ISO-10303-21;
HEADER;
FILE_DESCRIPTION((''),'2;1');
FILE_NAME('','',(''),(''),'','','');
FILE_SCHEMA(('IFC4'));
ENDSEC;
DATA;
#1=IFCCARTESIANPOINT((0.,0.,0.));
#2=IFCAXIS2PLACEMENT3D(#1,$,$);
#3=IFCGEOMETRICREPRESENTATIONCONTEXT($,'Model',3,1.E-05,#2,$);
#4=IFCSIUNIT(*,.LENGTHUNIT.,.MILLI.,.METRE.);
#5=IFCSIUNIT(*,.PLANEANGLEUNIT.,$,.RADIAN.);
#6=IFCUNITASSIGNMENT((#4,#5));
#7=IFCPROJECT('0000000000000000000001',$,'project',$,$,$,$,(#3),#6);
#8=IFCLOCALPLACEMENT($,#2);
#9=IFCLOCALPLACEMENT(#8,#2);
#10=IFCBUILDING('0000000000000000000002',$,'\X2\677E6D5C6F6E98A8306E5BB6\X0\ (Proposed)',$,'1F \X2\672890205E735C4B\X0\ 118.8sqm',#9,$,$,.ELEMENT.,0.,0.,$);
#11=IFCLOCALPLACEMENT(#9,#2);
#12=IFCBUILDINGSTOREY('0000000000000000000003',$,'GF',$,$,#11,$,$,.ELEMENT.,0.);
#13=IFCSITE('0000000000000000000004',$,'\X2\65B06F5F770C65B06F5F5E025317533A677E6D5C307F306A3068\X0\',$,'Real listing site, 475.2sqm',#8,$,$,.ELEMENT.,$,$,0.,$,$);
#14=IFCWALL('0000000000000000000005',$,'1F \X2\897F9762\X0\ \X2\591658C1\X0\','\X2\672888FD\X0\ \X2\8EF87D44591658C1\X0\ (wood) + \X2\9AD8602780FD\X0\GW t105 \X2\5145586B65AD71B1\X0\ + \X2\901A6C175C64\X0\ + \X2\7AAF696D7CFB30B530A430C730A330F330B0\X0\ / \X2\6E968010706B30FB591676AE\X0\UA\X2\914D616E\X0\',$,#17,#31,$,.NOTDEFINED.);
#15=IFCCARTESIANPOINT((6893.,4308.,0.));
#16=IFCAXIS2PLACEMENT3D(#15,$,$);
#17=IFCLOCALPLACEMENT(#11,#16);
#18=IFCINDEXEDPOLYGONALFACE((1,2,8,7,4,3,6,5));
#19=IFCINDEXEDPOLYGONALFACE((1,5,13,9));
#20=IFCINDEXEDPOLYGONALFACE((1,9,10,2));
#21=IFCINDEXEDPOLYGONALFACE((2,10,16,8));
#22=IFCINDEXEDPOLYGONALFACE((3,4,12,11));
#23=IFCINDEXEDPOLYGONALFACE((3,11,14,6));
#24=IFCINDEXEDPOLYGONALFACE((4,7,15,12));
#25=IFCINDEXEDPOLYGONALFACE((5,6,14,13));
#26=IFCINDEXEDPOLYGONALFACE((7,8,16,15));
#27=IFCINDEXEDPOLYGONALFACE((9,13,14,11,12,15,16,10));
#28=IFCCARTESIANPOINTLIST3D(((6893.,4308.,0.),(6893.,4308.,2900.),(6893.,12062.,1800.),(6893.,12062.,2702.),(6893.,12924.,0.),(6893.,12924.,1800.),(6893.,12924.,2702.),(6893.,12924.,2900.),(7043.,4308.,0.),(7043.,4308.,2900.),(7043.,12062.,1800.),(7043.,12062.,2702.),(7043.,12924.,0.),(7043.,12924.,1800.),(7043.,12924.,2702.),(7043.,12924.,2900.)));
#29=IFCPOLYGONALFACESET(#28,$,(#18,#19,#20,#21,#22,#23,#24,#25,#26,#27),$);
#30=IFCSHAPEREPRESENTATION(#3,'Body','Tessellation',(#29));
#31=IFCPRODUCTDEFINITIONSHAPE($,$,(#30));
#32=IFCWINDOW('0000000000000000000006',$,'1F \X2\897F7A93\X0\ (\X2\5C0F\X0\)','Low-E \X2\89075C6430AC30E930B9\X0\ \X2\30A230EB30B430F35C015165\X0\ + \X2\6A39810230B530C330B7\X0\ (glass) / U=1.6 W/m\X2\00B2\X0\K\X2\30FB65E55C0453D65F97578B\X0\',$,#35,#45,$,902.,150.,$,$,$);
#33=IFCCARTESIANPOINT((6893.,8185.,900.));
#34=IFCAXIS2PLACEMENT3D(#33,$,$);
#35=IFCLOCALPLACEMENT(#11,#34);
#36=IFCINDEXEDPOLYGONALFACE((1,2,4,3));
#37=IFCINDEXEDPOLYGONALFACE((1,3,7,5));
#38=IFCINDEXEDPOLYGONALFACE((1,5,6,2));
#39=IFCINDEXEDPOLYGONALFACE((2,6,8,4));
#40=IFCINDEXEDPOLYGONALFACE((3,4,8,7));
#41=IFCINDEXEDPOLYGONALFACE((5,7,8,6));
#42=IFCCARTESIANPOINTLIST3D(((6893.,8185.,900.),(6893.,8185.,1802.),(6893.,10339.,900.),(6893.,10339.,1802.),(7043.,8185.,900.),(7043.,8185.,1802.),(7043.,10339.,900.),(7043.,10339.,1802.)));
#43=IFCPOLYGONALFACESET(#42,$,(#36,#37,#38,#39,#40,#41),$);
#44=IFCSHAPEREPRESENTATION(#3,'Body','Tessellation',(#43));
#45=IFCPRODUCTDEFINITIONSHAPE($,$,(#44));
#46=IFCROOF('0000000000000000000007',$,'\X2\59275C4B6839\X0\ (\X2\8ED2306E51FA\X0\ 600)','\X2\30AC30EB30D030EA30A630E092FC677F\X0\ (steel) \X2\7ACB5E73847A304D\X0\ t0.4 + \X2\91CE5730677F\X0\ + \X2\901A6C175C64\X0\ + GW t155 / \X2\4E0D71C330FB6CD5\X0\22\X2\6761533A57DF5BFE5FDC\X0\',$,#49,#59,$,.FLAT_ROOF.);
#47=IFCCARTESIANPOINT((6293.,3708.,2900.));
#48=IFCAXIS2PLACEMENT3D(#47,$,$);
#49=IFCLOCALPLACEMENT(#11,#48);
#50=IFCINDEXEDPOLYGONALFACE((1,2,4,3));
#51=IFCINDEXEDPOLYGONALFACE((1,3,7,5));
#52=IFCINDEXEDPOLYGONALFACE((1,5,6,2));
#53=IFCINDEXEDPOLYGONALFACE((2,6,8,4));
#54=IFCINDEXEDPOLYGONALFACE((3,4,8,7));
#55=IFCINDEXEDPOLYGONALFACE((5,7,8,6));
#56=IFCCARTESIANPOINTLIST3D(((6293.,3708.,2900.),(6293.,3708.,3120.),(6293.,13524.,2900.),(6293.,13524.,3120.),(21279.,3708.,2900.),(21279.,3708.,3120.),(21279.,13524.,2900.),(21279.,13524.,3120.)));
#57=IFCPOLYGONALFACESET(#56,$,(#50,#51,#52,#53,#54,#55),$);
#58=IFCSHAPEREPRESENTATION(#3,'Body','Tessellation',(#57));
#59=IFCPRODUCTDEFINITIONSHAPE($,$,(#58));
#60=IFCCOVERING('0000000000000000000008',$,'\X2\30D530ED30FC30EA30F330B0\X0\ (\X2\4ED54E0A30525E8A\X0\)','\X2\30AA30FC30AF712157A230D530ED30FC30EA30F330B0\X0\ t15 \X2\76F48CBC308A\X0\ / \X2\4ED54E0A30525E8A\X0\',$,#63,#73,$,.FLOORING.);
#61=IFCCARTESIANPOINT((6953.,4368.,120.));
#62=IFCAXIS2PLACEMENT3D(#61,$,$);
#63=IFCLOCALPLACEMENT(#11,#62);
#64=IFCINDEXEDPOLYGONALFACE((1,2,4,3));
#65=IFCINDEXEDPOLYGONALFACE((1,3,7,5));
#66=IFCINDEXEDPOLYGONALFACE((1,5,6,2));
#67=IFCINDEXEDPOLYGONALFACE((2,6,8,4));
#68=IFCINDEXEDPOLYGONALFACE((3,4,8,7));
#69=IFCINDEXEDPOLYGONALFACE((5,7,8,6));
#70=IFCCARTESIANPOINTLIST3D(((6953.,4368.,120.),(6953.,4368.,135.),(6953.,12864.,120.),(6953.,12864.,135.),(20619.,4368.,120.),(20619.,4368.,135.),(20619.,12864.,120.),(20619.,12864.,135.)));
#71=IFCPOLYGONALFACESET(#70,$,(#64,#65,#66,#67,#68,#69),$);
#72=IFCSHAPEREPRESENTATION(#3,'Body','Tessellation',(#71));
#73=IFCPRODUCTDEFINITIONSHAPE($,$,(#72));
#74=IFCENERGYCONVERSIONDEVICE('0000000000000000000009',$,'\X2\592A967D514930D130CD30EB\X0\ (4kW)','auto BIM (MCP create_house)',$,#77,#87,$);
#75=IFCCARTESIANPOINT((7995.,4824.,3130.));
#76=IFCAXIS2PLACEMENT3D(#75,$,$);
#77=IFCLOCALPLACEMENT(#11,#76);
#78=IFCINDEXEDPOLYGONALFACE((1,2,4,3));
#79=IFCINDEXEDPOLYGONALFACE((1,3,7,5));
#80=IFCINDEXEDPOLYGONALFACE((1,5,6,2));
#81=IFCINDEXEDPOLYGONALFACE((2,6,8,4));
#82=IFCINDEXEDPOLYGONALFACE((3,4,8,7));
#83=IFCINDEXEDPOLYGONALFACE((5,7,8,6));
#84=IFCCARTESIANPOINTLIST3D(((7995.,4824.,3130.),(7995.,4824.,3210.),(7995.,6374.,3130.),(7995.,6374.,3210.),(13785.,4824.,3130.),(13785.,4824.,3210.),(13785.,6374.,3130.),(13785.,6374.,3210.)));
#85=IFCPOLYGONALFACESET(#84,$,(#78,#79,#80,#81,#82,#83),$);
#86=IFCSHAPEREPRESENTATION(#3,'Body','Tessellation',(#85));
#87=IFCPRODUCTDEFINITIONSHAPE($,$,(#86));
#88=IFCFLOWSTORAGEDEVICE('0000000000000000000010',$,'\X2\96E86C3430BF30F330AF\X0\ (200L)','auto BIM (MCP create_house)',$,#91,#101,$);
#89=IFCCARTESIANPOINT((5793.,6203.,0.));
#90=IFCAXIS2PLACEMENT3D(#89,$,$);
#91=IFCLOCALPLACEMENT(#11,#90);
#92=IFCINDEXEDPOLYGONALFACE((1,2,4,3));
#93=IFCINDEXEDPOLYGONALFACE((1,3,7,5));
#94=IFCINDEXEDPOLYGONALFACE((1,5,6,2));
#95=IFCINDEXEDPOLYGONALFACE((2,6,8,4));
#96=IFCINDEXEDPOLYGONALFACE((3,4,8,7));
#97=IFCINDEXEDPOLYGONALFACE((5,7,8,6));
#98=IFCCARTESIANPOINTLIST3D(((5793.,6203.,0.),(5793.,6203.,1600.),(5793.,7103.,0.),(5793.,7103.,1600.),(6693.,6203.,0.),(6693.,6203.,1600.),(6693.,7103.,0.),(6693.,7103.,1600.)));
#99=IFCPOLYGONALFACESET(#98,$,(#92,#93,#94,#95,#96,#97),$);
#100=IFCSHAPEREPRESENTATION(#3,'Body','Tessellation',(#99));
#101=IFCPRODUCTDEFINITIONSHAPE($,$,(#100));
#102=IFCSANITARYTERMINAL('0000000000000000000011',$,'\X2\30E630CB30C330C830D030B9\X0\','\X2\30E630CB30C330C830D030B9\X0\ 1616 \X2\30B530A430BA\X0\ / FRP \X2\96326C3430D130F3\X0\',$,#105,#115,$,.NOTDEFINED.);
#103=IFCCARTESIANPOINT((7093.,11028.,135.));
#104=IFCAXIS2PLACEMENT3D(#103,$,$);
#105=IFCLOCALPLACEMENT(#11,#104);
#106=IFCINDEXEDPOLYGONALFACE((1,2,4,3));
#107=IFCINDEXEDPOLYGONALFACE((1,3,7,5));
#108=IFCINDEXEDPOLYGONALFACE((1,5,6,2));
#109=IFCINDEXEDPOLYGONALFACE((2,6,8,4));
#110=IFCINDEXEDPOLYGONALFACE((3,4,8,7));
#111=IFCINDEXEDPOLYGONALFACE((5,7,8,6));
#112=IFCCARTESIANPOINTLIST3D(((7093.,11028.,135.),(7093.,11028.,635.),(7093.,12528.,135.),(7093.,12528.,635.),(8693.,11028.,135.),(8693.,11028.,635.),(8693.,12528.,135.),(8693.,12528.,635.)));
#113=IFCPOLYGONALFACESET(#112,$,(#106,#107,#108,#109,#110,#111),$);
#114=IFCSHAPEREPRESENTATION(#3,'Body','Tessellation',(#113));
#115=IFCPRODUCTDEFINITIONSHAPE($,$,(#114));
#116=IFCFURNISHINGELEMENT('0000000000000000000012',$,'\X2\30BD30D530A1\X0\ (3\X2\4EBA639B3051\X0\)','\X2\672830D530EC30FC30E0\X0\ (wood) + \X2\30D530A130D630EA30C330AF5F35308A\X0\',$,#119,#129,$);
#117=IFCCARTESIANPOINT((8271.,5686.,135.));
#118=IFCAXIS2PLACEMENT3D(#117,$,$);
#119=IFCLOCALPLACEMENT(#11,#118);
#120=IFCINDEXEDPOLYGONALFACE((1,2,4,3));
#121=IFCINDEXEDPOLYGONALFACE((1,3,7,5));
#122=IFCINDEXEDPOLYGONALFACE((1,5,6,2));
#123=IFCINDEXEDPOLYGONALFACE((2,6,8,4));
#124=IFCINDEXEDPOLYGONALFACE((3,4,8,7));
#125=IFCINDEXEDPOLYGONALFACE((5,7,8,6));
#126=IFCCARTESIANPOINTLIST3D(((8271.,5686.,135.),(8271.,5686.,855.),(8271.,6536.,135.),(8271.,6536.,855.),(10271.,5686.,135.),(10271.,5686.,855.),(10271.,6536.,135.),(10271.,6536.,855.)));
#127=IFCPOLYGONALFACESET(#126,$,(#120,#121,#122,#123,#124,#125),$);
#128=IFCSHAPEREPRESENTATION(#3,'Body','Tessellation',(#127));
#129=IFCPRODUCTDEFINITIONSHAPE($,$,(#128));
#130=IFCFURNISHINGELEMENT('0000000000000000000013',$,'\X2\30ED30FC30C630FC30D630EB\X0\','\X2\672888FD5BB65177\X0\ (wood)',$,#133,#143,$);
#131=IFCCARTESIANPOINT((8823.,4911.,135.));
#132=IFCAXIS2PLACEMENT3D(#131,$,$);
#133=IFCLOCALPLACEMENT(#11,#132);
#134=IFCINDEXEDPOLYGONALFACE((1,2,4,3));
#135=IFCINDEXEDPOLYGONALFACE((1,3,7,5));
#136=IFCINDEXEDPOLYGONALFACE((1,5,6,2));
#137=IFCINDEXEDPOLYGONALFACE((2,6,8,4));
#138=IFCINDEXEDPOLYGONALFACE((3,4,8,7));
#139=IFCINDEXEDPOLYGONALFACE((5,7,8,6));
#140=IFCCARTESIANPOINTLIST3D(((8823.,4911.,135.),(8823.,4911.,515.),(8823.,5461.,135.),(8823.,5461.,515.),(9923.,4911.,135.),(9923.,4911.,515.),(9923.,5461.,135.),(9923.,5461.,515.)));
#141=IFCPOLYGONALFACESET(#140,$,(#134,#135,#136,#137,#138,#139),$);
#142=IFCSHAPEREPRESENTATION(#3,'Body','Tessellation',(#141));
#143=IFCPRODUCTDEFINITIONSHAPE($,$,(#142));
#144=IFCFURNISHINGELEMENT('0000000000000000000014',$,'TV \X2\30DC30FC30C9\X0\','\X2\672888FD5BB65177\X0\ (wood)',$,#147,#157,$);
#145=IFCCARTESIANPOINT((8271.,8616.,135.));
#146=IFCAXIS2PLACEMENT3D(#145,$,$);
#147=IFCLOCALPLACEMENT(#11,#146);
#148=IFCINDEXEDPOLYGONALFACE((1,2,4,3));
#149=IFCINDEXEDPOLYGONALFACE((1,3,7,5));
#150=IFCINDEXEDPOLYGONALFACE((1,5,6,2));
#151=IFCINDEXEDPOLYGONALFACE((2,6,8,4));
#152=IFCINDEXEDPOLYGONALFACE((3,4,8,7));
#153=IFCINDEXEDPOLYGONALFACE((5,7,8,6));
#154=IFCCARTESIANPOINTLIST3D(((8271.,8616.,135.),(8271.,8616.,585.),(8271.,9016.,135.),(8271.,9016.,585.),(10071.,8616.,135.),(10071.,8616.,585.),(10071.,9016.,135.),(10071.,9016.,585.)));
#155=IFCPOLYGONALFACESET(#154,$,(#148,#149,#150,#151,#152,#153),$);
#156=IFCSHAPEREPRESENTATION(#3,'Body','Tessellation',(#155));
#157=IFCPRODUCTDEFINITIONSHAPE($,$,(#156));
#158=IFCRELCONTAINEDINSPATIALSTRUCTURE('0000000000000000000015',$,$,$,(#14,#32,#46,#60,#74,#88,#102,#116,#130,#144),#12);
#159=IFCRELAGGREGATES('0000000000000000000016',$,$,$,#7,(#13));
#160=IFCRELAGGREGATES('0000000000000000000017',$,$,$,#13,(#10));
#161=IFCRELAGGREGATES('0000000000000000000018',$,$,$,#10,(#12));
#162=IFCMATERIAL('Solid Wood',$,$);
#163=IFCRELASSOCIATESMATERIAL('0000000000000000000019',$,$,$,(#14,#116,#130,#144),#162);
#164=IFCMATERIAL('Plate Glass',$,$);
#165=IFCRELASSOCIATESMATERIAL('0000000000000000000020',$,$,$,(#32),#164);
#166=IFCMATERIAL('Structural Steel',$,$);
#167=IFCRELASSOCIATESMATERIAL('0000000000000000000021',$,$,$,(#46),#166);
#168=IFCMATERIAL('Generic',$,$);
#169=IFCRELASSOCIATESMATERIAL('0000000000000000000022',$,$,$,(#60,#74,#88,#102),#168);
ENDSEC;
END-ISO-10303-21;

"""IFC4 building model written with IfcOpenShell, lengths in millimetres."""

from ifc_helpers import new_model, si_unit, frame, frame_2d, origin, place, context, project, spatial, rectangle, extrude, material, element, fill, save


model = new_model("IFC4")

# Units and contexts
model_context = context("Model", 3, precision=1e-05, world=origin())
ifc_project = project(units=[si_unit("LENGTHUNIT", "METRE", prefix="MILLI"), si_unit("PLANEANGLEUNIT", "RADIAN")], contexts=[model_context])

# Site, building, storey
site_placement = place(None, origin())
site = spatial("IfcSite", under=ifc_project, at=site_placement, Name="新潟県新潟市北区松浜みなと", ObjectType="Real listing site, 475.2sqm", CompositionType="ELEMENT", RefElevation=0.0)
building_placement = place(site_placement, origin())
building = spatial("IfcBuilding", under=site, at=building_placement, Name="松浜潮風の家 (Proposed)", ObjectType="1F 木造平屋 118.8sqm", CompositionType="ELEMENT", ElevationOfRefHeight=0.0, ElevationOfTerrain=0.0)
storey_placement = place(building_placement, origin())
storey = spatial("IfcBuildingStorey", under=building, at=storey_placement, Name="GF", CompositionType="ELEMENT", Elevation=0.0)

# Shared definitions
ifc_material_1 = material(Name="Solid Wood")

# Shared definitions
ifc_material_2 = material(Name="Plate Glass")

# Wall, opening, window
wall_1_placement = place(storey_placement, frame((6893.0, 4308.0, 0.0)))
wall_1 = element("IfcWall", 1, at=wall_1_placement, inside=storey, material=ifc_material_1, Name="1F 西面 外壁", Description="木製 軸組外壁 (wood) + 高性能GW t105 充填断熱 + 通気層 + 窯業系サイディング / 準耐火・外皮UA配慮", PredefinedType="NOTDEFINED", context=model_context, shape_type="SweptSolid", body=[
    extrude(rectangle(XDim=150.0, YDim=8616.0, at=frame_2d((75.0, 4308.0))), frame((6893.0, 4308.0, 0.0)), (0.0, 0.0, 1.0), 2900.0),
])
opening_1_placement = place(storey_placement, frame((6893.0, 8185.0, 900.0)))
opening_1 = element("IfcOpeningElement", 2, at=opening_1_placement, cuts=wall_1, PredefinedType="NOTDEFINED", context=model_context, shape_type="SweptSolid", body=[
    extrude(rectangle(XDim=150.0, YDim=2154.0, at=frame_2d((75.0, 1077.0))), frame((6893.0, 8185.0, 900.0)), (0.0, 0.0, 1.0), 902.0),
])
window_1_placement = place(storey_placement, frame((6893.0, 8185.0, 900.0)))
window_1 = element("IfcWindow", 3, at=window_1_placement, inside=storey, material=ifc_material_2, Name="1F 西窓 (小)", Description="Low-E 複層ガラス アルゴン封入 + 樹脂サッシ (glass) / U=1.6 W/m²K・日射取得型", OverallHeight=902.0, OverallWidth=150.0, context=model_context, shape_type="SweptSolid", body=[
    extrude(rectangle(XDim=150.0, YDim=2154.0, at=frame_2d((75.0, 1077.0))), frame((6893.0, 8185.0, 900.0)), (0.0, 0.0, 1.0), 902.0),
])
fill(opening_1, window_1)

# Roof
ifc_material_3 = material(Name="Structural Steel")
roof_placement = place(storey_placement, frame((6293.0, 3708.0, 2900.0)))
element("IfcRoof", 4, at=roof_placement, inside=storey, material=ifc_material_3, Name="大屋根 (軒の出 600)", Description="ガルバリウム鋼板 (steel) 立平葺き t0.4 + 野地板 + 通気層 + GW t155 / 不燃・法22条区域対応", PredefinedType="FLAT_ROOF", context=model_context, shape_type="SweptSolid", body=[
    extrude(rectangle(XDim=14986.0, YDim=9816.0, at=frame_2d((7493.0, 4908.0))), frame((6293.0, 3708.0, 2900.0)), (0.0, 0.0, 1.0), 220.0),
])

# Covering
ifc_material_4 = material(Name="Generic")
covering_placement = place(storey_placement, frame((6953.0, 4368.0, 120.0)))
element("IfcCovering", 5, at=covering_placement, inside=storey, material=ifc_material_4, Name="フローリング (仕上げ床)", Description="オーク無垢フローリング t15 直貼り / 仕上げ床", PredefinedType="FLOORING", context=model_context, shape_type="SweptSolid", body=[
    extrude(rectangle(XDim=13666.0, YDim=8496.0, at=frame_2d((6833.0, 4248.0))), frame((6953.0, 4368.0, 120.0)), (0.0, 0.0, 1.0), 15.0),
])

# Energy conversion device
energy_conversion_device_placement = place(storey_placement, frame((7995.0, 4824.0, 3130.0)))
element("IfcEnergyConversionDevice", 6, at=energy_conversion_device_placement, inside=storey, material=ifc_material_4, Name="太陽光パネル (4kW)", Description="auto BIM (MCP create_house)", context=model_context, shape_type="SweptSolid", body=[
    extrude(rectangle(XDim=5790.0, YDim=1550.0, at=frame_2d((2895.0, 775.0))), frame((7995.0, 4824.0, 3130.0)), (0.0, 0.0, 1.0), 80.0),
])

# Flow storage device
flow_storage_device_placement = place(storey_placement, frame((5793.0, 6203.0, 0.0)))
element("IfcFlowStorageDevice", 7, at=flow_storage_device_placement, inside=storey, material=ifc_material_4, Name="雨水タンク (200L)", Description="auto BIM (MCP create_house)", context=model_context, shape_type="SweptSolid", body=[
    extrude(rectangle(XDim=900.0, YDim=900.0, at=frame_2d((450.0, 450.0))), frame((5793.0, 6203.0, 0.0)), (0.0, 0.0, 1.0), 1600.0),
])

# Sanitary terminal
sanitary_terminal_placement = place(storey_placement, frame((7093.0, 11028.0, 135.0)))
element("IfcSanitaryTerminal", 8, at=sanitary_terminal_placement, inside=storey, material=ifc_material_4, Name="ユニットバス", Description="ユニットバス 1616 サイズ / FRP 防水パン", PredefinedType="NOTDEFINED", context=model_context, shape_type="SweptSolid", body=[
    extrude(rectangle(XDim=1600.0, YDim=1500.0, at=frame_2d((800.0, 750.0))), frame((7093.0, 11028.0, 135.0)), (0.0, 0.0, 1.0), 500.0),
])

# Furnishing elements
furnishing_1_placement = place(storey_placement, frame((8271.0, 5686.0, 135.0)))
element("IfcFurnishingElement", 9, at=furnishing_1_placement, inside=storey, material=ifc_material_1, Name="ソファ (3人掛け)", Description="木フレーム (wood) + ファブリック張り", context=model_context, shape_type="SweptSolid", body=[
    extrude(rectangle(XDim=2000.0, YDim=850.0, at=frame_2d((1000.0, 425.0))), frame((8271.0, 5686.0, 135.0)), (0.0, 0.0, 1.0), 720.0),
])
furnishing_2_placement = place(storey_placement, frame((8823.0, 4911.0, 135.0)))
element("IfcFurnishingElement", 10, at=furnishing_2_placement, inside=storey, material=ifc_material_1, Name="ローテーブル", Description="木製家具 (wood)", context=model_context, shape_type="SweptSolid", body=[
    extrude(rectangle(XDim=1100.0, YDim=550.0, at=frame_2d((550.0, 275.0))), frame((8823.0, 4911.0, 135.0)), (0.0, 0.0, 1.0), 380.0),
])
furnishing_3_placement = place(storey_placement, frame((8271.0, 8616.0, 135.0)))
element("IfcFurnishingElement", 11, at=furnishing_3_placement, inside=storey, material=ifc_material_1, Name="TV ボード", Description="木製家具 (wood)", context=model_context, shape_type="SweptSolid", body=[
    extrude(rectangle(XDim=1800.0, YDim=400.0, at=frame_2d((900.0, 200.0))), frame((8271.0, 8616.0, 135.0)), (0.0, 0.0, 1.0), 450.0),
])

save(model, "model.ifc")
